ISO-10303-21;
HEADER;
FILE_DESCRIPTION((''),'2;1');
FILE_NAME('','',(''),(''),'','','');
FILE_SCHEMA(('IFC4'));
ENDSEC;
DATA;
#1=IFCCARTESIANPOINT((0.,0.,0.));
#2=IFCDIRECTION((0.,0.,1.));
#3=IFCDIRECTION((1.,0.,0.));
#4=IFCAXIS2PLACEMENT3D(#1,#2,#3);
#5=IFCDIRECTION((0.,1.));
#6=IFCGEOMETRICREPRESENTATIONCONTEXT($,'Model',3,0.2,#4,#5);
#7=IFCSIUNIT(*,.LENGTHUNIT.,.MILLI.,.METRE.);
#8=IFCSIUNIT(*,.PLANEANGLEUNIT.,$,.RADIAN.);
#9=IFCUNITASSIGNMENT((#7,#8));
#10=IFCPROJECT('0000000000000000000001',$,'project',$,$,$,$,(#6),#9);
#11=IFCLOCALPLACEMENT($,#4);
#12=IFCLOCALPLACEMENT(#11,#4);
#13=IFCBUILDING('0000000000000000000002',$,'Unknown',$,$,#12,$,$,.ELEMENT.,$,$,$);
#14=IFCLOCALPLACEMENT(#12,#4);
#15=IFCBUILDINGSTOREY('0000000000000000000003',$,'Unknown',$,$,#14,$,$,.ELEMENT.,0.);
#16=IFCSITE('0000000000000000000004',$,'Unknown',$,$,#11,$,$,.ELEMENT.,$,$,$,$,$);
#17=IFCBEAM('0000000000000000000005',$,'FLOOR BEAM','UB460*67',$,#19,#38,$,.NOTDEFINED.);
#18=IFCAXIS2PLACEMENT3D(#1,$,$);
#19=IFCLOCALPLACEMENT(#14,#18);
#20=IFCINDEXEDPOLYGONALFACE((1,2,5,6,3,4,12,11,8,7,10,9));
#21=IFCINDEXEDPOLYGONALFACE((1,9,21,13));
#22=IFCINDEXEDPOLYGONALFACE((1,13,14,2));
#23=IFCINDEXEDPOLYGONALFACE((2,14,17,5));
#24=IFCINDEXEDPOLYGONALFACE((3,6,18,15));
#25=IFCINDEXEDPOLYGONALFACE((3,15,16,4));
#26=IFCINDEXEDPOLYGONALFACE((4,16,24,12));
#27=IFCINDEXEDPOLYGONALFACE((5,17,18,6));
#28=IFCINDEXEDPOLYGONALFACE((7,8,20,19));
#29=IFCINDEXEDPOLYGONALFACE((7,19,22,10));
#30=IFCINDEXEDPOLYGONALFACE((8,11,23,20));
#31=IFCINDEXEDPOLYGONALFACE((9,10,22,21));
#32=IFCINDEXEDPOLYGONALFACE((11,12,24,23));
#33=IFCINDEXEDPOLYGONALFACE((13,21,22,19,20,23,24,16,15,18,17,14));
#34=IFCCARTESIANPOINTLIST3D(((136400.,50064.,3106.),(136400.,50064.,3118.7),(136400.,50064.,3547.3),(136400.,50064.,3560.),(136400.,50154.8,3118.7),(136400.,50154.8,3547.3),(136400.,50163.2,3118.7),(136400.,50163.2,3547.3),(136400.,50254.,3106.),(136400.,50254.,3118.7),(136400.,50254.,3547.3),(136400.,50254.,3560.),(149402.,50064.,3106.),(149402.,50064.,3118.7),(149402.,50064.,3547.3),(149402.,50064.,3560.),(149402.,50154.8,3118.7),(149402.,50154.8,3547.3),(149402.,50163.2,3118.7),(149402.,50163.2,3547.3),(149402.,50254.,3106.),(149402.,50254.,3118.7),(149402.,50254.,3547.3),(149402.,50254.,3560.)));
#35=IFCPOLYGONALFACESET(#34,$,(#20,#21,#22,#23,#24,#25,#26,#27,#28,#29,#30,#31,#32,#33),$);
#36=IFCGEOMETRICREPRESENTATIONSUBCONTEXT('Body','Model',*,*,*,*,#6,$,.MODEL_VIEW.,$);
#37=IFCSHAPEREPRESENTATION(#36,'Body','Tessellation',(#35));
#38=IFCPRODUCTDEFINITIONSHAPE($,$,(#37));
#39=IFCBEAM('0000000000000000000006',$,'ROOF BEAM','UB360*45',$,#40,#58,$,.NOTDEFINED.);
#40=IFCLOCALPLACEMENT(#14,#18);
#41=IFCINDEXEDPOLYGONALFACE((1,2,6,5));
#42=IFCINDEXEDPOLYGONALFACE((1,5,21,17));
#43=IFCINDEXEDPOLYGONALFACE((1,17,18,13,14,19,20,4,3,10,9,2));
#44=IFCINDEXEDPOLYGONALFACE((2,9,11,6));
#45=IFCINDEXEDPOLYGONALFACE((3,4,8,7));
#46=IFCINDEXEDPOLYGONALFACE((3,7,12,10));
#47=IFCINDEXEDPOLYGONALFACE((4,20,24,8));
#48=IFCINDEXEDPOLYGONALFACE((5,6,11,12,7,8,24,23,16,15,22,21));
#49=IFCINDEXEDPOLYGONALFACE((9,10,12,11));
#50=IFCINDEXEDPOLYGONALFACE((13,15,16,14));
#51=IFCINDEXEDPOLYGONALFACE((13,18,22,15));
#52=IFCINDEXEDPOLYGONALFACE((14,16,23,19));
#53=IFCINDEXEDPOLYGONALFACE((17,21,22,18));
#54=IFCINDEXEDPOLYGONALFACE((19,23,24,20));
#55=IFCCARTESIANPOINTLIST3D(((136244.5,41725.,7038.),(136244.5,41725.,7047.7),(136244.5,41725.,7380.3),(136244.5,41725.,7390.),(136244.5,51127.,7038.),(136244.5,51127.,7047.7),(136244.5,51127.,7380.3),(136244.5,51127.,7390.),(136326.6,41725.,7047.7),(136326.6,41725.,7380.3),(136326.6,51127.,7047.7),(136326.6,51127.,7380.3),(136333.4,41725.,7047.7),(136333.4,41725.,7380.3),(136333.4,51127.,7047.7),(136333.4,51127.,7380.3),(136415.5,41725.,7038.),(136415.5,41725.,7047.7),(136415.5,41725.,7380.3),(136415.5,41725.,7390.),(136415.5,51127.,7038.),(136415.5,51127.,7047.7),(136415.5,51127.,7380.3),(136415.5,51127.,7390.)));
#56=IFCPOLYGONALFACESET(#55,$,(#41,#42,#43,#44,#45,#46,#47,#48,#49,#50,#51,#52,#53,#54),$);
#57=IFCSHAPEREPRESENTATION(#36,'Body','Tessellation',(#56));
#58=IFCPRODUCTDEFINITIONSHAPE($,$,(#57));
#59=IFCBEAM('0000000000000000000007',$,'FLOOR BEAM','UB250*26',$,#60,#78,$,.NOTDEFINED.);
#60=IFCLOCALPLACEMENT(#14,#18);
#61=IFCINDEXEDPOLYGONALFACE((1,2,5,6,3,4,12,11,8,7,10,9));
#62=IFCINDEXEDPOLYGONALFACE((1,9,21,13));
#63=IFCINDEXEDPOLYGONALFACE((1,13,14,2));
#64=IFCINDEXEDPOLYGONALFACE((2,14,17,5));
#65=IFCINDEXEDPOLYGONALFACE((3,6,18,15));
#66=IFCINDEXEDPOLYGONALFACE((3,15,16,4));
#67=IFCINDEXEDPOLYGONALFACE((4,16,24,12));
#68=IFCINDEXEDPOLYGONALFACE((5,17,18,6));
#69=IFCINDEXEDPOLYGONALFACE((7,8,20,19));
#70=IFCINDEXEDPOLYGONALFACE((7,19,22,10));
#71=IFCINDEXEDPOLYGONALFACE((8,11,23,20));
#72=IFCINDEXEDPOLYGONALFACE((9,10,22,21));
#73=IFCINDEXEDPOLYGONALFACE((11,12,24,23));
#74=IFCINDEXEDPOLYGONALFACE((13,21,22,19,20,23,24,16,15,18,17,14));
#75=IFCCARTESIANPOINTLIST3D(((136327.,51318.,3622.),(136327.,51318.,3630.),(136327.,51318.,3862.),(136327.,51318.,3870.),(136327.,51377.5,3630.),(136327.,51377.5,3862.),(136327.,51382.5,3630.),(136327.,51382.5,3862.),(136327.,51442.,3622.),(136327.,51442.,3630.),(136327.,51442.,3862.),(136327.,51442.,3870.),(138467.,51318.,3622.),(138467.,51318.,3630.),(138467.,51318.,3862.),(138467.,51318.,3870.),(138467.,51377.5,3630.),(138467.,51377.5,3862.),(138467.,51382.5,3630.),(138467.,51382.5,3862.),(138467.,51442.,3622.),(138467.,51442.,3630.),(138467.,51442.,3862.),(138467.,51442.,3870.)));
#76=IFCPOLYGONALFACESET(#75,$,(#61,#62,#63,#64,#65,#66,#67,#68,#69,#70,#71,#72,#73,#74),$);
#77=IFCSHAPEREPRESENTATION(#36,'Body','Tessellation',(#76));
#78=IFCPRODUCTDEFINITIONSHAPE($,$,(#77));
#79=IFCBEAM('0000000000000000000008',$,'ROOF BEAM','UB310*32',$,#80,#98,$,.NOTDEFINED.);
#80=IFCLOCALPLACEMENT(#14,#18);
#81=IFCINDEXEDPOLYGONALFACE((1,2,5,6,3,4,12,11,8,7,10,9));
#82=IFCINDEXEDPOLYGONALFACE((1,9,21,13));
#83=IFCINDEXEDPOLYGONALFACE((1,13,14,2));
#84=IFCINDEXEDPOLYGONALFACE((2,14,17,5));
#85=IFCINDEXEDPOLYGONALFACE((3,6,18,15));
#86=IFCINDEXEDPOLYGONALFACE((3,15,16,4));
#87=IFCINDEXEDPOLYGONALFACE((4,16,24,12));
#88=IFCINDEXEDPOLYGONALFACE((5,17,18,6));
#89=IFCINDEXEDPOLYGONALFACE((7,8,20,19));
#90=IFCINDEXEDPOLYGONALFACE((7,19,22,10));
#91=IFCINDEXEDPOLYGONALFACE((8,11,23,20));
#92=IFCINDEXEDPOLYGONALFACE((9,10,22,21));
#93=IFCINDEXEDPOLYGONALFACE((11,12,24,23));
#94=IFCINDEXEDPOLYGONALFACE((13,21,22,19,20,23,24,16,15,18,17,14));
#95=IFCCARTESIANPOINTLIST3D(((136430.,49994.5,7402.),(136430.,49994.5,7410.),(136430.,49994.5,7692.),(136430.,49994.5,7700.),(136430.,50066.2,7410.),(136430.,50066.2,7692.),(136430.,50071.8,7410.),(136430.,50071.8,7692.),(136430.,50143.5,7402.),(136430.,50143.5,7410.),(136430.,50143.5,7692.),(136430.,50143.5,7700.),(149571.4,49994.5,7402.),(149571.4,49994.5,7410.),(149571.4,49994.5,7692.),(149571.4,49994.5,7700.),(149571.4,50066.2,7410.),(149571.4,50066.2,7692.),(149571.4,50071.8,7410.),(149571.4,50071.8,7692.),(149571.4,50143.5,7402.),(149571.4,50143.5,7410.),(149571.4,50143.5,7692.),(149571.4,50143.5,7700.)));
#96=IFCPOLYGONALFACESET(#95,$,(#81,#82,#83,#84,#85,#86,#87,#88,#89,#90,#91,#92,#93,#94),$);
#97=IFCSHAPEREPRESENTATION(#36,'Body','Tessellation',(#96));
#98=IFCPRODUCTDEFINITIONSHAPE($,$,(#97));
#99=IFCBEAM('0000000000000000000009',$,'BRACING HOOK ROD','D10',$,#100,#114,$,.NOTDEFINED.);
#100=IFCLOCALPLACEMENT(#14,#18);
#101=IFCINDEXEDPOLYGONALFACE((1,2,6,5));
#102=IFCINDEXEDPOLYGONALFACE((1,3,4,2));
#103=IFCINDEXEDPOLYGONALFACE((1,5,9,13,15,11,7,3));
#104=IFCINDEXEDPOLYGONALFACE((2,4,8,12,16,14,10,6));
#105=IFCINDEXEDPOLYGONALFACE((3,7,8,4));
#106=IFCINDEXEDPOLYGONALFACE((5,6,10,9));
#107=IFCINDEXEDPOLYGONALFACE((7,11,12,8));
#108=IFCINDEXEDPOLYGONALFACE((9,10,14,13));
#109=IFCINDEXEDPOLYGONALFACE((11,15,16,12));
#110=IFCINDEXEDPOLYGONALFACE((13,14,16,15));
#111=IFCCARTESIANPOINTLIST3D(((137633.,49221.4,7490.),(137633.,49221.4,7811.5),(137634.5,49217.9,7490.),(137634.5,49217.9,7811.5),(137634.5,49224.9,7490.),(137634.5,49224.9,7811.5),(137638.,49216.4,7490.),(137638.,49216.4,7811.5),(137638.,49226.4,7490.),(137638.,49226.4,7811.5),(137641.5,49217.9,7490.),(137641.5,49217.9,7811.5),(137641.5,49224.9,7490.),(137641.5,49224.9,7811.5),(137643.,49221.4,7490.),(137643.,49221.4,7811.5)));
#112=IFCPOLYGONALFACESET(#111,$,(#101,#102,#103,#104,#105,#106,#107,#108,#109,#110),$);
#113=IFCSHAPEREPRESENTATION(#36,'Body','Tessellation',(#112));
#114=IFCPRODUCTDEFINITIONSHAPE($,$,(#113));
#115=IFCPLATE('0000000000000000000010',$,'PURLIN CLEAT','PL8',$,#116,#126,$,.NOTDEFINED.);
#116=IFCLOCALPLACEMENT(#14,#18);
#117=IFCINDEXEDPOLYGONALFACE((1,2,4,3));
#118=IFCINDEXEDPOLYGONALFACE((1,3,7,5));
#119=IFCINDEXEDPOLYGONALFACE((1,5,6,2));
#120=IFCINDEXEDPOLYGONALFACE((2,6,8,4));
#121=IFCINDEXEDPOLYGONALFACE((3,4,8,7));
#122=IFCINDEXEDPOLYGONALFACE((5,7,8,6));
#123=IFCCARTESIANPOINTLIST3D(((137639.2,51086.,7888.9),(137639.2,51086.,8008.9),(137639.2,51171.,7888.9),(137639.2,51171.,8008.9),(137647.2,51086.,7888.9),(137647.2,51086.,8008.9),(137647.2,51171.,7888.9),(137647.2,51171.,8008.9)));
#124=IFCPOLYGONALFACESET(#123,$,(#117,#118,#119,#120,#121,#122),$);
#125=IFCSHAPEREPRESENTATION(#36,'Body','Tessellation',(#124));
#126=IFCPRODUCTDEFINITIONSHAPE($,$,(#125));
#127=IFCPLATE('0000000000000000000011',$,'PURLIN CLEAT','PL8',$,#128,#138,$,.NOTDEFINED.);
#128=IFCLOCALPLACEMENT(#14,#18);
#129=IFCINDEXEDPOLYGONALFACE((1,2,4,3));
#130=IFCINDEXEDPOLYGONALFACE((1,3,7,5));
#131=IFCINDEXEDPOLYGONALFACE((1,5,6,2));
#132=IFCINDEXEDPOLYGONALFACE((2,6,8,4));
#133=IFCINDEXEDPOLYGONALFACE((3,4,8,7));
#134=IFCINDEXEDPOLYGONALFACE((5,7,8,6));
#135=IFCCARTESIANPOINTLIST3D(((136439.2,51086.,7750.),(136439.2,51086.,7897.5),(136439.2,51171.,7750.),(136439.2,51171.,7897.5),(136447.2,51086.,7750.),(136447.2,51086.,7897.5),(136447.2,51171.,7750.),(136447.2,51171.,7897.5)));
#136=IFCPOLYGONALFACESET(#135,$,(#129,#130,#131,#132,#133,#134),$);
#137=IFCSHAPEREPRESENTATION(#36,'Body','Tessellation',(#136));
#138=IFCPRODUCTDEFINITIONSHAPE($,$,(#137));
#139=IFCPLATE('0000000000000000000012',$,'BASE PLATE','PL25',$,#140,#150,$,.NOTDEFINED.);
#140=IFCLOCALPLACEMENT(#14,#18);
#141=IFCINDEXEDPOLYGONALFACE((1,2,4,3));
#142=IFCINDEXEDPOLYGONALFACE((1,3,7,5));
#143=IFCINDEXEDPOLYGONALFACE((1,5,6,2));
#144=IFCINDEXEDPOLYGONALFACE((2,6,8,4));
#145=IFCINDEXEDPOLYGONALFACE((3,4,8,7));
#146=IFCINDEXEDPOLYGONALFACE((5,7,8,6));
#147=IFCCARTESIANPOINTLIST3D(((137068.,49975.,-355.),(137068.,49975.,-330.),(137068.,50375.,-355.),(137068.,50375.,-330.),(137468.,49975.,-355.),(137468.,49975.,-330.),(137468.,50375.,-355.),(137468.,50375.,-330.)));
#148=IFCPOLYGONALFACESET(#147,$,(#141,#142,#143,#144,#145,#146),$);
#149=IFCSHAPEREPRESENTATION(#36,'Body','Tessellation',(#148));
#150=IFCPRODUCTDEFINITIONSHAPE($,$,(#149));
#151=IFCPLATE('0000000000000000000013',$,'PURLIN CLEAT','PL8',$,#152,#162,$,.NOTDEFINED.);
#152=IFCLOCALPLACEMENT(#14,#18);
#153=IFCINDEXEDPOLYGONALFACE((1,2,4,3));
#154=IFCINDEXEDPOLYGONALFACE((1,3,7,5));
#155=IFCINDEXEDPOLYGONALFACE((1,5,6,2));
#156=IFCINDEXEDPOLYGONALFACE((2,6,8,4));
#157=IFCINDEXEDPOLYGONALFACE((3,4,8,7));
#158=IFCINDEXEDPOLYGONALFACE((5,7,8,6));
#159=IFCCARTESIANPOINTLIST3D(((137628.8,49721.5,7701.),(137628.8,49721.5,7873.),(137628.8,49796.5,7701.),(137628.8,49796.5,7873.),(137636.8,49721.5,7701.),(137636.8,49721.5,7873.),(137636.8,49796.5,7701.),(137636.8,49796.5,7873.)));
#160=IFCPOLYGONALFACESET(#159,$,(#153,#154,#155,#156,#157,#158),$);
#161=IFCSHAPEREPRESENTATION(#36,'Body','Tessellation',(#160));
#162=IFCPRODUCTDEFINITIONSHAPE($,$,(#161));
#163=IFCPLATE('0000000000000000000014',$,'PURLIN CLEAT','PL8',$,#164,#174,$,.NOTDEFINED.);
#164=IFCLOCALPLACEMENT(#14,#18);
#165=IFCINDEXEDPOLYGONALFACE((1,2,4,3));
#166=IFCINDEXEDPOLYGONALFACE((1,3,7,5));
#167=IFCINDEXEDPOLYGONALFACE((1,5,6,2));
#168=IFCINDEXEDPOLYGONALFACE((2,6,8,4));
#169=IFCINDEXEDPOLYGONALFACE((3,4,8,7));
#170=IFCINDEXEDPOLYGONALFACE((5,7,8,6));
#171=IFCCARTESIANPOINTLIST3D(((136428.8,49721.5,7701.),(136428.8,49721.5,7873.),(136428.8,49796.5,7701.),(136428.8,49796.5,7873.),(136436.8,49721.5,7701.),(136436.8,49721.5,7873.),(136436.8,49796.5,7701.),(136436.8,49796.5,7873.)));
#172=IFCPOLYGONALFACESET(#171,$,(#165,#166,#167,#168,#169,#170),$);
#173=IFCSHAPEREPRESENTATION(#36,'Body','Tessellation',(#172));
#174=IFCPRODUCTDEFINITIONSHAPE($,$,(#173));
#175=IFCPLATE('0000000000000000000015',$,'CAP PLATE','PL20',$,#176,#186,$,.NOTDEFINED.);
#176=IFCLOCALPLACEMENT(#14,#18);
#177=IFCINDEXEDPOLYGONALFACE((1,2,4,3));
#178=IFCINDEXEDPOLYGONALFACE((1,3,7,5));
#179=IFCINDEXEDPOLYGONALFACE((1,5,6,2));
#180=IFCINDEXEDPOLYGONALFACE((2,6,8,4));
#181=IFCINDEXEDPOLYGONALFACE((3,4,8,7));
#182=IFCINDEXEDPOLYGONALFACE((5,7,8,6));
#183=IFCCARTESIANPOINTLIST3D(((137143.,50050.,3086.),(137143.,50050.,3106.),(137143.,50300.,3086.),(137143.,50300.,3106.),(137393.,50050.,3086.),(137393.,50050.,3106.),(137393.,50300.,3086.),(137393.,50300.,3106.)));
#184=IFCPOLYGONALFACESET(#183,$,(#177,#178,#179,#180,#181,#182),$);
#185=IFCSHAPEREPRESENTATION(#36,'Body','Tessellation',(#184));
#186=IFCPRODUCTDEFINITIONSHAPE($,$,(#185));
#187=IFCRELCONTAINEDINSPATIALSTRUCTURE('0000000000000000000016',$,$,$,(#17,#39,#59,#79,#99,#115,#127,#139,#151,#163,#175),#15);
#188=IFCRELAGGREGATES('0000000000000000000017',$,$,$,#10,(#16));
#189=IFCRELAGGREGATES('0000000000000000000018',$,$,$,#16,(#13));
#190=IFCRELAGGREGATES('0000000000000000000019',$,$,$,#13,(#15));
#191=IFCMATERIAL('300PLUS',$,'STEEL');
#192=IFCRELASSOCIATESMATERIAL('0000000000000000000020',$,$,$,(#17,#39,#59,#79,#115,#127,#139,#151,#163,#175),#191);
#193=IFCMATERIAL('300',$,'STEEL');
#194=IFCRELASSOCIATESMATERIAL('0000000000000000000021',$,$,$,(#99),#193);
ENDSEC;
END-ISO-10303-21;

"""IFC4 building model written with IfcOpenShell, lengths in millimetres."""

from ifc_helpers import new_model, si_unit, direction, frame, origin_with_axes, place, context, subcontext, project, spatial, line, indexed_curve, outline, extrude, material, element, save


model = new_model("IFC4")

# Units and contexts
model_context = context("Model", 3, precision=0.2, world=origin_with_axes(), true_north=direction((0.0, 1.0)))
body_context = subcontext(model_context, "Body", "Model", "MODEL_VIEW")
ifc_project = project(units=[si_unit("LENGTHUNIT", "METRE", prefix="MILLI"), si_unit("PLANEANGLEUNIT", "RADIAN")], contexts=[model_context])

# Site, building, storey
site_placement = place(None, origin_with_axes())
site = spatial("IfcSite", under=ifc_project, at=site_placement, Name="Unknown", CompositionType="ELEMENT")
building_placement = place(site_placement, origin_with_axes())
building = spatial("IfcBuilding", under=site, at=building_placement, Name="Unknown", CompositionType="ELEMENT")
storey_placement = place(building_placement, origin_with_axes())
storey = spatial("IfcBuildingStorey", under=building, at=storey_placement, Name="Unknown", CompositionType="ELEMENT", Elevation=0.0)

# Beams
ifc_material_1 = material(Name="300PLUS", Category="STEEL")
beam_1_placement = place(storey_placement, frame((136400.0, 50159.0, 3333.0), z_axis=(0.0, -1.0, 0.0), x_axis=(1.0, 0.0, 0.0)))
element("IfcBeam", 1, at=beam_1_placement, inside=storey, material=ifc_material_1, Name="FLOOR BEAM", Description="UB460*67", PredefinedType="NOTDEFINED", context=body_context, shape_type="SolidModel", body=[
    extrude(outline(indexed_curve([(-95.0, -227.0), (95.0, -227.0), (95.0, -214.3), (4.2, -214.3), (4.2, 214.3), (95.0, 214.3), (95.0, 227.0), (-95.0, 227.0), (-95.0, 214.3), (-4.2, 214.3), (-4.2, -214.3), (-95.0, -214.3)], segments=[line(1, 2, 3, 4, 5, 6, 7, 8, 9, 10, 11, 12, 1)])), frame((0.0, 0.0, 0.0), z_axis=(-1.0, 0.0, 0.0), x_axis=(0.0, 0.0, 1.0)), (0.0, 0.0, -1.0), 13002.0),
])
beam_2_placement = place(storey_placement, frame((136330.0, 51127.0, 7214.0), z_axis=(-1.0, 0.0, 0.0), x_axis=(0.0, -1.0, 0.0)))
element("IfcBeam", 2, at=beam_2_placement, inside=storey, material=ifc_material_1, Name="ROOF BEAM", Description="UB360*45", PredefinedType="NOTDEFINED", context=body_context, shape_type="SolidModel", body=[
    extrude(outline(indexed_curve([(-85.5, -176.0), (85.5, -176.0), (85.5, -166.3), (3.5, -166.3), (3.5, 166.3), (85.5, 166.3), (85.5, 176.0), (-85.5, 176.0), (-85.5, 166.3), (-3.5, 166.3), (-3.5, -166.3), (-85.5, -166.3)], segments=[line(1, 2, 3, 4, 5, 6, 7, 8, 9, 10, 11, 12, 1)])), frame((0.0, 0.0, 0.0), z_axis=(-1.0, 0.0, 0.0), x_axis=(0.0, 0.0, 1.0)), (0.0, 0.0, -1.0), 9402.0),
])
beam_3_placement = place(storey_placement, frame((136327.0, 51380.0, 3746.0), z_axis=(0.0, -1.0, 0.0), x_axis=(1.0, 0.0, 0.0)))
element("IfcBeam", 3, at=beam_3_placement, inside=storey, material=ifc_material_1, Name="FLOOR BEAM", Description="UB250*26", PredefinedType="NOTDEFINED", context=body_context, shape_type="SolidModel", body=[
    extrude(outline(indexed_curve([(-62.0, -124.0), (62.0, -124.0), (62.0, -116.0), (2.5, -116.0), (2.5, 116.0), (62.0, 116.0), (62.0, 124.0), (-62.0, 124.0), (-62.0, 116.0), (-2.5, 116.0), (-2.5, -116.0), (-62.0, -116.0)], segments=[line(1, 2, 3, 4, 5, 6, 7, 8, 9, 10, 11, 12, 1)])), frame((0.0, 0.0, 0.0), z_axis=(-1.0, 0.0, 0.0), x_axis=(0.0, 0.0, 1.0)), (0.0, 0.0, -1.0), 2140.0),
])
beam_4_placement = place(storey_placement, frame((136430.0, 50069.0, 7551.0), z_axis=(0.0, -1.0, 0.0), x_axis=(1.0, 0.0, 0.0)))
element("IfcBeam", 4, at=beam_4_placement, inside=storey, material=ifc_material_1, Name="ROOF BEAM", Description="UB310*32", PredefinedType="NOTDEFINED", context=body_context, shape_type="SolidModel", body=[
    extrude(outline(indexed_curve([(-74.5, -149.0), (74.5, -149.0), (74.5, -141.0), (2.8, -141.0), (2.8, 141.0), (74.5, 141.0), (74.5, 149.0), (-74.5, 149.0), (-74.5, 141.0), (-2.8, 141.0), (-2.8, -141.0), (-74.5, -141.0)], segments=[line(1, 2, 3, 4, 5, 6, 7, 8, 9, 10, 11, 12, 1)])), frame((0.0, 0.0, 0.0), z_axis=(-1.0, 0.0, 0.0), x_axis=(0.0, 0.0, 1.0)), (0.0, 0.0, -1.0), 13141.4),
])
ifc_material_2 = material(Name="300", Category="STEEL")
beam_5_placement = place(storey_placement, frame((137638.0, 49221.4, 7811.5), z_axis=(1.0, 0.0, 0.0), x_axis=(0.0, 0.0, -1.0)))
element("IfcBeam", 5, at=beam_5_placement, inside=storey, material=ifc_material_2, Name="BRACING HOOK ROD", Description="D10", PredefinedType="NOTDEFINED", context=body_context, shape_type="SolidModel", body=[
    extrude(outline(indexed_curve([(5.0, 0.0), (3.5, 3.5), (0.0, 5.0), (-3.5, 3.5), (-5.0, 0.0), (-3.5, -3.5), (0.0, -5.0), (3.5, -3.5)], segments=[line(1, 2, 3, 4, 5, 6, 7, 8, 1)])), frame((0.0, 0.0, 0.0), z_axis=(-1.0, 0.0, 0.0), x_axis=(0.0, 0.0, 1.0)), (0.0, 0.0, -1.0), 321.5),
])

# Plates
plate_1_placement = place(storey_placement, frame((137643.2, 51171.0, 8008.9), z_axis=(1.0, 0.0, 0.0), x_axis=(0.0, -1.0, 0.0)))
element("IfcPlate", 6, at=plate_1_placement, inside=storey, material=ifc_material_1, Name="PURLIN CLEAT", Description="PL8", PredefinedType="NOTDEFINED", context=body_context, shape_type="SolidModel", body=[
    extrude(outline(indexed_curve([(0.0, 0.0), (85.0, 0.0), (85.0, 120.0), (0.0, 120.0)], segments=[line(1, 2, 3, 4, 1)])), frame((0.0, 0.0, 4.0), z_axis=(0.0, 0.0, 1.0), x_axis=(1.0, 0.0, 0.0)), (0.0, 0.0, -1.0), 8.0),
])
plate_2_placement = place(storey_placement, frame((136443.2, 51171.0, 7897.5), z_axis=(1.0, 0.0, 0.0), x_axis=(0.0, -1.0, 0.0)))
element("IfcPlate", 7, at=plate_2_placement, inside=storey, material=ifc_material_1, Name="PURLIN CLEAT", Description="PL8", PredefinedType="NOTDEFINED", context=body_context, shape_type="SolidModel", body=[
    extrude(outline(indexed_curve([(0.0, 0.0), (85.0, 0.0), (85.0, 147.5), (0.0, 147.5)], segments=[line(1, 2, 3, 4, 1)])), frame((0.0, 0.0, 4.0), z_axis=(0.0, 0.0, 1.0), x_axis=(1.0, 0.0, 0.0)), (0.0, 0.0, -1.0), 8.0),
])
plate_3_placement = place(storey_placement, frame((137068.0, 49975.0, -342.5), z_axis=(0.0, 0.0, 1.0), x_axis=(1.0, 0.0, 0.0)))
element("IfcPlate", 8, at=plate_3_placement, inside=storey, material=ifc_material_1, Name="BASE PLATE", Description="PL25", PredefinedType="NOTDEFINED", context=body_context, shape_type="SolidModel", body=[
    extrude(outline(indexed_curve([(0.0, 0.0), (400.0, 0.0), (400.0, 400.0), (0.0, 400.0)], segments=[line(1, 2, 3, 4, 1)])), frame((0.0, 0.0, 12.5), z_axis=(0.0, 0.0, 1.0), x_axis=(1.0, 0.0, 0.0)), (0.0, 0.0, -1.0), 25.0),
])
for number, where, z_axis, x_axis, name in (
    (9, (137632.8, 49721.5, 7873.0), (-1.0, 0.0, 0.0), (0.0, 1.0, 0.0), "PURLIN CLEAT"),
    (10, (136432.8, 49721.5, 7873.0), (-1.0, 0.0, 0.0), (0.0, 1.0, 0.0), "PURLIN CLEAT"),
):
    element("IfcPlate", number, at=place(storey_placement, frame(where, z_axis=z_axis, x_axis=x_axis)), inside=storey, material=ifc_material_1, Name=name, Description="PL8", PredefinedType="NOTDEFINED", context=body_context, shape_type="SolidModel", body=[
        extrude(outline(indexed_curve([(0.0, 0.0), (75.0, 0.0), (75.0, 172.0), (0.0, 172.0)], segments=[line(1, 2, 3, 4, 1)])), frame((0.0, 0.0, 4.0), z_axis=(0.0, 0.0, 1.0), x_axis=(1.0, 0.0, 0.0)), (0.0, 0.0, -1.0), 8.0),
    ])
plate_4_placement = place(storey_placement, frame((137143.0, 50050.0, 3096.0), z_axis=(0.0, 0.0, 1.0), x_axis=(1.0, 0.0, 0.0)))
element("IfcPlate", 11, at=plate_4_placement, inside=storey, material=ifc_material_1, Name="CAP PLATE", Description="PL20", PredefinedType="NOTDEFINED", context=body_context, shape_type="SolidModel", body=[
    extrude(outline(indexed_curve([(0.0, 0.0), (250.0, 0.0), (250.0, 250.0), (0.0, 250.0)], segments=[line(1, 2, 3, 4, 1)])), frame((0.0, 0.0, 10.0), z_axis=(0.0, 0.0, 1.0), x_axis=(1.0, 0.0, 0.0)), (0.0, 0.0, -1.0), 20.0),
])

save(model, "model.ifc")
